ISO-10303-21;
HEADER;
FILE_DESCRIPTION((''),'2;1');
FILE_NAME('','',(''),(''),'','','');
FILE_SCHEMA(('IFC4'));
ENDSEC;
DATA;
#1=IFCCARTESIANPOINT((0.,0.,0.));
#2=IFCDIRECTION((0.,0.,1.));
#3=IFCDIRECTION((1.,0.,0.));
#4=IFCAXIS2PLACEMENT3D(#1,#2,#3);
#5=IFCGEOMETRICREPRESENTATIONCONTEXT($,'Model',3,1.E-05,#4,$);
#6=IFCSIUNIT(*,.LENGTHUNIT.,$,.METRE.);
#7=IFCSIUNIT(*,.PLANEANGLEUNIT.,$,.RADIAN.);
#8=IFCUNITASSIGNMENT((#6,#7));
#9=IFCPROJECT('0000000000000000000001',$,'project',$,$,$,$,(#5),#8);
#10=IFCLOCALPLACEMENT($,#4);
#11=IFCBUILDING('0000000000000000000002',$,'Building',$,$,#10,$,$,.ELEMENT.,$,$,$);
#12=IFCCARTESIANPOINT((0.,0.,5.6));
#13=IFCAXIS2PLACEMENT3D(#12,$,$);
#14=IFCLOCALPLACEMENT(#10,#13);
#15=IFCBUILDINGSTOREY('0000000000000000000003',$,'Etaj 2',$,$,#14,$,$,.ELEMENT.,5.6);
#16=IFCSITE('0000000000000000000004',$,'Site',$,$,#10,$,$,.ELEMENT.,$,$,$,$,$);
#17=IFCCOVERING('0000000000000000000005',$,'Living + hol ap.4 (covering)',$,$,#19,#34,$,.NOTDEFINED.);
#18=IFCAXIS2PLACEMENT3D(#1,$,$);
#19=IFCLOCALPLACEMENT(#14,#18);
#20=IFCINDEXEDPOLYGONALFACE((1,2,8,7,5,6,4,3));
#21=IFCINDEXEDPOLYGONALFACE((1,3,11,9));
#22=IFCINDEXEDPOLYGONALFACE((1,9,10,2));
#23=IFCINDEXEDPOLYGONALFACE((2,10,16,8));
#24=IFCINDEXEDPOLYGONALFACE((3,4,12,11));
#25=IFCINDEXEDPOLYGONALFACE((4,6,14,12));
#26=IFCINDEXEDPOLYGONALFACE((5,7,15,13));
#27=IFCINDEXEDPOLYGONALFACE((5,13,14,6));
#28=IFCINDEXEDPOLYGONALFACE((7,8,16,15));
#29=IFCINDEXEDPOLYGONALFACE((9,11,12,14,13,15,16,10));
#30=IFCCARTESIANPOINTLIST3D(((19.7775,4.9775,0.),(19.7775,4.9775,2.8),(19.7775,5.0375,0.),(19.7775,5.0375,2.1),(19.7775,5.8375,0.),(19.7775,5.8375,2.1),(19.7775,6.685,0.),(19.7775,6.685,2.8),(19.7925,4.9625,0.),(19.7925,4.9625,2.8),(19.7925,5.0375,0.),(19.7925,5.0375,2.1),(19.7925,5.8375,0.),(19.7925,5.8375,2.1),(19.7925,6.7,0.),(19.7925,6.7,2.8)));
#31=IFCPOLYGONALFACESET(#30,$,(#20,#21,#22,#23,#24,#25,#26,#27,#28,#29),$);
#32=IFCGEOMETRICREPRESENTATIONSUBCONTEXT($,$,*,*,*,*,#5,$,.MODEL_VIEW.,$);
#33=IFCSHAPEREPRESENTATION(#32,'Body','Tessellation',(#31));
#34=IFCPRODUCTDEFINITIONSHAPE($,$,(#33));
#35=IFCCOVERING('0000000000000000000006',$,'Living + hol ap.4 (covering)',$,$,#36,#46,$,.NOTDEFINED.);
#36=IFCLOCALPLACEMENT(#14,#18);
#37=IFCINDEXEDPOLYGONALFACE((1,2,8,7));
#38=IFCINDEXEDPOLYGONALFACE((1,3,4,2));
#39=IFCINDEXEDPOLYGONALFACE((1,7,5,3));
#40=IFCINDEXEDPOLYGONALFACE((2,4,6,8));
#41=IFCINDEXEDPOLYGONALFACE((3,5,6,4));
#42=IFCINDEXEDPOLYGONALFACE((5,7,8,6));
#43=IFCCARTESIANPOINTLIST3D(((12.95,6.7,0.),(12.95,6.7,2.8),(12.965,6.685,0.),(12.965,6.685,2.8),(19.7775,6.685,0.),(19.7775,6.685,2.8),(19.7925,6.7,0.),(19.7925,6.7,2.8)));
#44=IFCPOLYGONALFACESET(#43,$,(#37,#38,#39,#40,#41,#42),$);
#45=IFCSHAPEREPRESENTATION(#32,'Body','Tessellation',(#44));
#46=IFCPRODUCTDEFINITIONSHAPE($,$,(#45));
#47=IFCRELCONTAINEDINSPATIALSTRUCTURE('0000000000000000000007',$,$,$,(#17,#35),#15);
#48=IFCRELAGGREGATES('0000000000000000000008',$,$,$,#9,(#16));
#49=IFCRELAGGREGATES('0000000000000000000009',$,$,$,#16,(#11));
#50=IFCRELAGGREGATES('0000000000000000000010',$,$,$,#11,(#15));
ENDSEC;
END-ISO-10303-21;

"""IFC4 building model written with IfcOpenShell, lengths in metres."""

from ifc_helpers import new_model, si_unit, frame, origin, origin_with_axes, origin_2d, place, context, subcontext, project, spatial, polyline, rectangle, outline, extrude, element, save


model = new_model("IFC4")

# Units and contexts
model_context = context("Model", 3, precision=1e-05, world=origin_with_axes())
sub_context = subcontext(model_context, None, None, "MODEL_VIEW")
ifc_project = project(units=[si_unit("LENGTHUNIT", "METRE"), si_unit("PLANEANGLEUNIT", "RADIAN")], contexts=[model_context])

# Site, building, storey
placement = place(None, origin_with_axes())
site = spatial("IfcSite", under=ifc_project, at=placement, Name="Site", CompositionType="ELEMENT")
building = spatial("IfcBuilding", under=site, at=placement, Name="Building", CompositionType="ELEMENT")
storey_placement = place(placement, frame((0.0, 0.0, 5.6)))
storey = spatial("IfcBuildingStorey", under=building, at=storey_placement, Name="Etaj 2", CompositionType="ELEMENT", Elevation=5.6)

# Covering, opening
covering_1_placement = place(storey_placement, origin_with_axes())
covering_1 = element("IfcCovering", 1, at=covering_1_placement, inside=storey, Name="Living + hol ap.4 (covering)", PredefinedType="NOTDEFINED", context=sub_context, shape_type="SweptSolid", body=[
    extrude(outline(polyline([(19.7925, 4.9625), (19.7925, 6.7), (19.7775, 6.685), (19.7775, 4.9775), (19.7925, 4.9625)])), origin(), (0.0, 0.0, 1.0), 2.8),
])
opening_1_placement = place(covering_1_placement, frame((19.7275, 5.4375, 0.0), z_axis=(1.0, 0.0, 0.0), x_axis=(0.0, 1.0, 0.0)))
element("IfcOpeningElement", 2, at=opening_1_placement, cuts=covering_1, PredefinedType="OPENING", context=sub_context, shape_type="SweptSolid", body=[
    extrude(rectangle(XDim=0.8, YDim=2.1, at=origin_2d()), frame((0.0, 1.05, 0.0)), (0.0, 0.0, 1.0), 0.38),
])

# Covering
covering_2_placement = place(storey_placement, origin_with_axes())
element("IfcCovering", 3, at=covering_2_placement, inside=storey, Name="Living + hol ap.4 (covering)", PredefinedType="NOTDEFINED", context=sub_context, shape_type="SweptSolid", body=[
    extrude(outline(polyline([(19.7925, 6.7), (12.95, 6.7), (12.965, 6.685), (19.7775, 6.685), (19.7925, 6.7)])), origin(), (0.0, 0.0, 1.0), 2.8),
])

save(model, "model.ifc")
